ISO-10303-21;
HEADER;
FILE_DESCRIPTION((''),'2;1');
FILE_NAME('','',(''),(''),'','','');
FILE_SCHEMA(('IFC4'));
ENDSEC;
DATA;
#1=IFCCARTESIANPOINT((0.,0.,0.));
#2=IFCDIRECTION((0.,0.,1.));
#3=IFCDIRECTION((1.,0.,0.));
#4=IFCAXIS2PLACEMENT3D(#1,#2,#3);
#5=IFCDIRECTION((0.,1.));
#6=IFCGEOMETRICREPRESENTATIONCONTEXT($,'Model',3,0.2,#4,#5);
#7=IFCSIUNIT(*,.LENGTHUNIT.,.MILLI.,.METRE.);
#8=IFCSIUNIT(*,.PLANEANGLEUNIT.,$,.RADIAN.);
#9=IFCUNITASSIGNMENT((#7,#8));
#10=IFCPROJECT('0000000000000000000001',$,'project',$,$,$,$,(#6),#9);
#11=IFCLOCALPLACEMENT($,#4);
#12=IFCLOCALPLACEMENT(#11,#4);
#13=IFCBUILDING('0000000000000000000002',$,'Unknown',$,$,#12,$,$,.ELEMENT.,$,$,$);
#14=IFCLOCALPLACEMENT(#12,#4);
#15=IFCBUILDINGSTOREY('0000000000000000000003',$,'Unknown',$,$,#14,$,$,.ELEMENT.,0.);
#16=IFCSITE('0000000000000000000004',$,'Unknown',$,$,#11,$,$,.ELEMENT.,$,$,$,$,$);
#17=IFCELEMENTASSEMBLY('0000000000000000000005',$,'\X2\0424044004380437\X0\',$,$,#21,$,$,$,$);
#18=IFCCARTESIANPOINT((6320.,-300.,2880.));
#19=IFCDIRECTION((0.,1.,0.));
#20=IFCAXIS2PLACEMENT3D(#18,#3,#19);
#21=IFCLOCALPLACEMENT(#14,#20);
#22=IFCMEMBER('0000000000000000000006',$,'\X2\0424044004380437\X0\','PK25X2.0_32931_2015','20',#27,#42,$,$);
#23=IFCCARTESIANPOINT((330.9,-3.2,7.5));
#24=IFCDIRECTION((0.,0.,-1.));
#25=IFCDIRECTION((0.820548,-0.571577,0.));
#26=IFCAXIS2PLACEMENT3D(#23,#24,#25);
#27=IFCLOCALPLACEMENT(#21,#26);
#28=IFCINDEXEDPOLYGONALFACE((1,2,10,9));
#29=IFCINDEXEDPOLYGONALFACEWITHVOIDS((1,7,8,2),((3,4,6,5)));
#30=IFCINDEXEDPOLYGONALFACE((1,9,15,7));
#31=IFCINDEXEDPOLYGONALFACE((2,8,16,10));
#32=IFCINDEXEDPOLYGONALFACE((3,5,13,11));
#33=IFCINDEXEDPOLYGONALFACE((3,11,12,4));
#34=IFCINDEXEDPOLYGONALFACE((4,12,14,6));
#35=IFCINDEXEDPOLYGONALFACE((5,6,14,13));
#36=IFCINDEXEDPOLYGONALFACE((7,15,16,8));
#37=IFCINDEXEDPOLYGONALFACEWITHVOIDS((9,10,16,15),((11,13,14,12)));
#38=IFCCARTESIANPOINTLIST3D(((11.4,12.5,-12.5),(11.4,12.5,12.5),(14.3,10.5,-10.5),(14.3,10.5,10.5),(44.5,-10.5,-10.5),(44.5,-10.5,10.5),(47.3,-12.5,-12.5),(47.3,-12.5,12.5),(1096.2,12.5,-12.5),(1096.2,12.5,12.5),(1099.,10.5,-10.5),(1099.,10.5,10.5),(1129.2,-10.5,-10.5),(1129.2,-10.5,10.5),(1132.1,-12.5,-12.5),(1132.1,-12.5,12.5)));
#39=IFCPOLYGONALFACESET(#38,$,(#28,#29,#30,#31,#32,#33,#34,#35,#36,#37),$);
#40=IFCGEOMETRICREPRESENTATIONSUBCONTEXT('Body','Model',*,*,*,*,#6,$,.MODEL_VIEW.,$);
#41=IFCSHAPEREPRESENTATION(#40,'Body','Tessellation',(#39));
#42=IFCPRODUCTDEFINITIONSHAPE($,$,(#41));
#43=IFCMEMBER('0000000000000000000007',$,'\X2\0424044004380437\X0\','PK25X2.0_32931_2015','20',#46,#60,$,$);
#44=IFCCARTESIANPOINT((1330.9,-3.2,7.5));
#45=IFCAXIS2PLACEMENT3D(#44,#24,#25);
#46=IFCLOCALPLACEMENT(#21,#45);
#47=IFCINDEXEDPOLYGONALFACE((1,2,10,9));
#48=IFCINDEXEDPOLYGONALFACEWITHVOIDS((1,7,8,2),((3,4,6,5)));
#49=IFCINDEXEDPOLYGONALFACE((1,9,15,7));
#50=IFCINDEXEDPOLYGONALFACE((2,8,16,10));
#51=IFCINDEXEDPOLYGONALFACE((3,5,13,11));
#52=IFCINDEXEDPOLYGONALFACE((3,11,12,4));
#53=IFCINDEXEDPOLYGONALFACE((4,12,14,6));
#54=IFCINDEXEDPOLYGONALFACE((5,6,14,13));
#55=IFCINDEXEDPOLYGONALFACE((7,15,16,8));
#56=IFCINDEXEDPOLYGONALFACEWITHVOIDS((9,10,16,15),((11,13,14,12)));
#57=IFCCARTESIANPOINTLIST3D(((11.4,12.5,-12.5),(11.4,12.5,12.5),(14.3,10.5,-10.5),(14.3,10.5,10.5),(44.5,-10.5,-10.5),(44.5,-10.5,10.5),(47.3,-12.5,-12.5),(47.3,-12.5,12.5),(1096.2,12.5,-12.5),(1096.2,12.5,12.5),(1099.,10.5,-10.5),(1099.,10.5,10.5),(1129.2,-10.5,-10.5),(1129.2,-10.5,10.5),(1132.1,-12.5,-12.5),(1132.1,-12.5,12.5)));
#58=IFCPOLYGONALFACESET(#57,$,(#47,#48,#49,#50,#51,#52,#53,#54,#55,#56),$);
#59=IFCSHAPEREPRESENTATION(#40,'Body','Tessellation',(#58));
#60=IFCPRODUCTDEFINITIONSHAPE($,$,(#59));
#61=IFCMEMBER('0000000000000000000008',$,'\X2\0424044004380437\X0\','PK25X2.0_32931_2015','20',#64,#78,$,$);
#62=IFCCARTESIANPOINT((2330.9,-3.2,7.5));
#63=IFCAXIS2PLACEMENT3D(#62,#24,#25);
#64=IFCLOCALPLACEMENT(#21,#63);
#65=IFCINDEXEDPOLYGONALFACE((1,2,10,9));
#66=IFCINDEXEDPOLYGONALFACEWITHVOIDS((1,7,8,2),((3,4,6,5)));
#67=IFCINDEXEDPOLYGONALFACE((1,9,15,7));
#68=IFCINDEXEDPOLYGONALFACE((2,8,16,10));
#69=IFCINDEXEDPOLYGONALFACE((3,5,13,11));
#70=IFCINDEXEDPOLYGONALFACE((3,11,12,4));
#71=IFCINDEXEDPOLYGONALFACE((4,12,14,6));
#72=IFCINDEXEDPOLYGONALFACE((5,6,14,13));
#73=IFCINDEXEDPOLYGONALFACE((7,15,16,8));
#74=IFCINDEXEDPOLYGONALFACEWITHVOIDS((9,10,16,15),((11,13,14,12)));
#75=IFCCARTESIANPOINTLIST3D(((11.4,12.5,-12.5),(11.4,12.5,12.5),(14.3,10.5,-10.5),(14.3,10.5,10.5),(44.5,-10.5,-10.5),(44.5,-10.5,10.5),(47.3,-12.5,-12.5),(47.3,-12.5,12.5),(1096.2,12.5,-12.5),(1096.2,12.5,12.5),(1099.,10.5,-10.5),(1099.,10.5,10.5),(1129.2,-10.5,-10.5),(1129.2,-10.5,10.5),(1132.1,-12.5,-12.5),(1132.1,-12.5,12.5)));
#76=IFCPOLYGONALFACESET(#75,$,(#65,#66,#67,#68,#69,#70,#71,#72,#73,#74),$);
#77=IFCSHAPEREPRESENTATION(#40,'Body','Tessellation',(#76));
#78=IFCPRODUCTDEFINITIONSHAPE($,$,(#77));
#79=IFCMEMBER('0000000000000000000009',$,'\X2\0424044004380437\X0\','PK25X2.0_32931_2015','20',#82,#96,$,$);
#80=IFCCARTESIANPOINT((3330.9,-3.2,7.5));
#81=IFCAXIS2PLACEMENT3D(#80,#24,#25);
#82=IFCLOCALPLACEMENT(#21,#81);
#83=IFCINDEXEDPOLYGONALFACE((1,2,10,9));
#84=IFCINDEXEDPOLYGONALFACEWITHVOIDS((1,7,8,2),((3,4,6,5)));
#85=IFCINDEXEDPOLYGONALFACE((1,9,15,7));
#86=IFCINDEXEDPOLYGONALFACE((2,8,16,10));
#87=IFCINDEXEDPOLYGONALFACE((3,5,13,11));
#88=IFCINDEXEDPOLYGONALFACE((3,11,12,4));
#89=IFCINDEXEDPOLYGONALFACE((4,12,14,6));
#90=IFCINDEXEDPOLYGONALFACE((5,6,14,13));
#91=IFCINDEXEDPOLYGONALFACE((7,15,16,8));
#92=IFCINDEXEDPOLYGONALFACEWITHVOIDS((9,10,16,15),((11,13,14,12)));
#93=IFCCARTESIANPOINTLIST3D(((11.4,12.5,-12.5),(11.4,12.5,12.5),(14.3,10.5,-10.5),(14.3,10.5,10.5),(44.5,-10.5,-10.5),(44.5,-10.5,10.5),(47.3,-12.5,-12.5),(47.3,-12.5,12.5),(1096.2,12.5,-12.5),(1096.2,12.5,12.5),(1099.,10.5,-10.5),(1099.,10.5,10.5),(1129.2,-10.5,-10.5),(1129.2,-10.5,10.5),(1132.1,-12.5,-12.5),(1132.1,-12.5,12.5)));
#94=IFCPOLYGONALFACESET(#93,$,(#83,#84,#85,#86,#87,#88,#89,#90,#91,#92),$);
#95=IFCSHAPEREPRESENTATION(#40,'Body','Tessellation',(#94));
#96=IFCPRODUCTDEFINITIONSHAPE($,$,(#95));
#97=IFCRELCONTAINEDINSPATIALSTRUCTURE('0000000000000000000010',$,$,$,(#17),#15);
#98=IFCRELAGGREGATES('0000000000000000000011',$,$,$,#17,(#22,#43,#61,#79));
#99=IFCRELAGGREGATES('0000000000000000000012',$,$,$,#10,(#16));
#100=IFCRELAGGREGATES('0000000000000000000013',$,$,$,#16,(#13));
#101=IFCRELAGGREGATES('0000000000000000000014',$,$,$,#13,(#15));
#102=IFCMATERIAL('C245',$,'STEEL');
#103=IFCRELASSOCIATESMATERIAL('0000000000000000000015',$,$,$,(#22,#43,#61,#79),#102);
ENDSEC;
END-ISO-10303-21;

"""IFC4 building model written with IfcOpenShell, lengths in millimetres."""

from ifc_helpers import new_model, si_unit, direction, frame, origin_with_axes, place, context, subcontext, project, spatial, line, indexed_curve, outline, extrude, material, element, aggregate, save


model = new_model("IFC4")

# Units and contexts
model_context = context("Model", 3, precision=0.2, world=origin_with_axes(), true_north=direction((0.0, 1.0)))
body_context = subcontext(model_context, "Body", "Model", "MODEL_VIEW")
ifc_project = project(units=[si_unit("LENGTHUNIT", "METRE", prefix="MILLI"), si_unit("PLANEANGLEUNIT", "RADIAN")], contexts=[model_context])

# Site, building, storey
site_placement = place(None, origin_with_axes())
site = spatial("IfcSite", under=ifc_project, at=site_placement, Name="Unknown", CompositionType="ELEMENT")
building_placement = place(site_placement, origin_with_axes())
building = spatial("IfcBuilding", under=site, at=building_placement, Name="Unknown", CompositionType="ELEMENT")
storey_placement = place(building_placement, origin_with_axes())
storey = spatial("IfcBuildingStorey", under=building, at=storey_placement, Name="Unknown", CompositionType="ELEMENT", Elevation=0.0)

# Shared definitions
ifc_material_1 = material(Name="C245", Category="STEEL")

# Element assembly, members, voiding features
assembly_1_placement = place(storey_placement, frame((6320.0, -300.0, 2880.0), z_axis=(1.0, 0.0, 0.0), x_axis=(0.0, 1.0, 0.0)))
assembly_1 = element("IfcElementAssembly", 1, at=assembly_1_placement, inside=storey, Name="Фриз")
member_1_placement = place(assembly_1_placement, frame((330.9, -3.2, 7.5), z_axis=(0.0, 0.0, -1.0), x_axis=(0.820548, -0.571577, 0.0)))
member_1 = element("IfcMember", 2, at=member_1_placement, material=ifc_material_1, Name="Фриз", Description="PK25X2.0_32931_2015", ObjectType="20", context=body_context, shape_type="SolidModel", body=[
    extrude(outline(indexed_curve([(-12.5, -12.5), (12.5, -12.5), (12.5, 12.5), (-12.5, 12.5)], segments=[line(1, 2, 3, 4, 1)]), holes=[indexed_curve([(-10.5, -10.5), (-10.5, 10.5), (10.5, 10.5), (10.5, -10.5)], segments=[line(1, 2, 3, 4, 1)])]), frame((0.0, 0.0, 0.0), z_axis=(-1.0, 0.0, 0.0), x_axis=(0.0, 0.0, 1.0)), (0.0, 0.0, -1.0), 1143.5),
])
voiding_feature_1_placement = place(member_1_placement, frame((-910.3, 630.2, 7.5), z_axis=(0.0, 0.0, -1.0), x_axis=(0.820548, -0.571577, 0.0)))
element("IfcVoidingFeature", 3, at=voiding_feature_1_placement, cuts=member_1, Name="CUT_BEAM", ObjectType="(?)", PredefinedType="HOLE", context=body_context, shape_type="SolidModel", body=[
    extrude(outline(indexed_curve([(-20.0, -20.0), (20.0, -20.0), (20.0, 20.0), (-20.0, 20.0)], segments=[line(1, 2, 3, 4, 1)])), frame((0.0, 0.0, 0.0), z_axis=(-1.0, 0.0, 0.0), x_axis=(0.0, 0.0, 1.0)), (0.0, 0.0, -1.0), 2205.1),
])
voiding_feature_2_placement = place(member_1_placement, frame((244.4, 630.2, 7.5), z_axis=(0.0, 0.0, -1.0), x_axis=(0.820548, -0.571577, 0.0)))
element("IfcVoidingFeature", 4, at=voiding_feature_2_placement, cuts=member_1, Name="CUT_BEAM", ObjectType="(?)", PredefinedType="HOLE", context=body_context, shape_type="SolidModel", body=[
    extrude(outline(indexed_curve([(-20.0, -20.0), (20.0, -20.0), (20.0, 20.0), (-20.0, 20.0)], segments=[line(1, 2, 3, 4, 1)])), frame((0.0, 0.0, 0.0), z_axis=(-1.0, 0.0, 0.0), x_axis=(0.0, 0.0, 1.0)), (0.0, 0.0, -1.0), 2205.1),
])
member_2_placement = place(assembly_1_placement, frame((1330.9, -3.2, 7.5), z_axis=(0.0, 0.0, -1.0), x_axis=(0.820548, -0.571577, 0.0)))
member_2 = element("IfcMember", 5, at=member_2_placement, material=ifc_material_1, Name="Фриз", Description="PK25X2.0_32931_2015", ObjectType="20", context=body_context, shape_type="SolidModel", body=[
    extrude(outline(indexed_curve([(-12.5, -12.5), (12.5, -12.5), (12.5, 12.5), (-12.5, 12.5)], segments=[line(1, 2, 3, 4, 1)]), holes=[indexed_curve([(-10.5, -10.5), (-10.5, 10.5), (10.5, 10.5), (10.5, -10.5)], segments=[line(1, 2, 3, 4, 1)])]), frame((0.0, 0.0, 0.0), z_axis=(-1.0, 0.0, 0.0), x_axis=(0.0, 0.0, 1.0)), (0.0, 0.0, -1.0), 1143.5),
])
voiding_feature_3_placement = place(member_2_placement, frame((-910.3, 630.2, 7.5), z_axis=(0.0, 0.0, -1.0), x_axis=(0.820548, -0.571577, 0.0)))
element("IfcVoidingFeature", 6, at=voiding_feature_3_placement, cuts=member_2, Name="CUT_BEAM", ObjectType="(?)", PredefinedType="HOLE", context=body_context, shape_type="SolidModel", body=[
    extrude(outline(indexed_curve([(-20.0, -20.0), (20.0, -20.0), (20.0, 20.0), (-20.0, 20.0)], segments=[line(1, 2, 3, 4, 1)])), frame((0.0, 0.0, 0.0), z_axis=(-1.0, 0.0, 0.0), x_axis=(0.0, 0.0, 1.0)), (0.0, 0.0, -1.0), 2205.1),
])
voiding_feature_4_placement = place(member_2_placement, frame((244.4, 630.2, 7.5), z_axis=(0.0, 0.0, -1.0), x_axis=(0.820548, -0.571577, 0.0)))
element("IfcVoidingFeature", 7, at=voiding_feature_4_placement, cuts=member_2, Name="CUT_BEAM", ObjectType="(?)", PredefinedType="HOLE", context=body_context, shape_type="SolidModel", body=[
    extrude(outline(indexed_curve([(-20.0, -20.0), (20.0, -20.0), (20.0, 20.0), (-20.0, 20.0)], segments=[line(1, 2, 3, 4, 1)])), frame((0.0, 0.0, 0.0), z_axis=(-1.0, 0.0, 0.0), x_axis=(0.0, 0.0, 1.0)), (0.0, 0.0, -1.0), 2205.1),
])
member_3_placement = place(assembly_1_placement, frame((2330.9, -3.2, 7.5), z_axis=(0.0, 0.0, -1.0), x_axis=(0.820548, -0.571577, 0.0)))
member_3 = element("IfcMember", 8, at=member_3_placement, material=ifc_material_1, Name="Фриз", Description="PK25X2.0_32931_2015", ObjectType="20", context=body_context, shape_type="SolidModel", body=[
    extrude(outline(indexed_curve([(-12.5, -12.5), (12.5, -12.5), (12.5, 12.5), (-12.5, 12.5)], segments=[line(1, 2, 3, 4, 1)]), holes=[indexed_curve([(-10.5, -10.5), (-10.5, 10.5), (10.5, 10.5), (10.5, -10.5)], segments=[line(1, 2, 3, 4, 1)])]), frame((0.0, 0.0, 0.0), z_axis=(-1.0, 0.0, 0.0), x_axis=(0.0, 0.0, 1.0)), (0.0, 0.0, -1.0), 1143.5),
])
voiding_feature_5_placement = place(member_3_placement, frame((-910.3, 630.2, 7.5), z_axis=(0.0, 0.0, -1.0), x_axis=(0.820548, -0.571577, 0.0)))
element("IfcVoidingFeature", 9, at=voiding_feature_5_placement, cuts=member_3, Name="CUT_BEAM", ObjectType="(?)", PredefinedType="HOLE", context=body_context, shape_type="SolidModel", body=[
    extrude(outline(indexed_curve([(-20.0, -20.0), (20.0, -20.0), (20.0, 20.0), (-20.0, 20.0)], segments=[line(1, 2, 3, 4, 1)])), frame((0.0, 0.0, 0.0), z_axis=(-1.0, 0.0, 0.0), x_axis=(0.0, 0.0, 1.0)), (0.0, 0.0, -1.0), 2205.1),
])
voiding_feature_6_placement = place(member_3_placement, frame((244.4, 630.2, 7.5), z_axis=(0.0, 0.0, -1.0), x_axis=(0.820548, -0.571577, 0.0)))
element("IfcVoidingFeature", 10, at=voiding_feature_6_placement, cuts=member_3, Name="CUT_BEAM", ObjectType="(?)", PredefinedType="HOLE", context=body_context, shape_type="SolidModel", body=[
    extrude(outline(indexed_curve([(-20.0, -20.0), (20.0, -20.0), (20.0, 20.0), (-20.0, 20.0)], segments=[line(1, 2, 3, 4, 1)])), frame((0.0, 0.0, 0.0), z_axis=(-1.0, 0.0, 0.0), x_axis=(0.0, 0.0, 1.0)), (0.0, 0.0, -1.0), 2205.1),
])
member_4_placement = place(assembly_1_placement, frame((3330.9, -3.2, 7.5), z_axis=(0.0, 0.0, -1.0), x_axis=(0.820548, -0.571577, 0.0)))
member_4 = element("IfcMember", 11, at=member_4_placement, material=ifc_material_1, Name="Фриз", Description="PK25X2.0_32931_2015", ObjectType="20", context=body_context, shape_type="SolidModel", body=[
    extrude(outline(indexed_curve([(-12.5, -12.5), (12.5, -12.5), (12.5, 12.5), (-12.5, 12.5)], segments=[line(1, 2, 3, 4, 1)]), holes=[indexed_curve([(-10.5, -10.5), (-10.5, 10.5), (10.5, 10.5), (10.5, -10.5)], segments=[line(1, 2, 3, 4, 1)])]), frame((0.0, 0.0, 0.0), z_axis=(-1.0, 0.0, 0.0), x_axis=(0.0, 0.0, 1.0)), (0.0, 0.0, -1.0), 1143.5),
])
voiding_feature_7_placement = place(member_4_placement, frame((-910.3, 630.2, 7.5), z_axis=(0.0, 0.0, -1.0), x_axis=(0.820548, -0.571577, 0.0)))
element("IfcVoidingFeature", 12, at=voiding_feature_7_placement, cuts=member_4, Name="CUT_BEAM", ObjectType="(?)", PredefinedType="HOLE", context=body_context, shape_type="SolidModel", body=[
    extrude(outline(indexed_curve([(-20.0, -20.0), (20.0, -20.0), (20.0, 20.0), (-20.0, 20.0)], segments=[line(1, 2, 3, 4, 1)])), frame((0.0, 0.0, 0.0), z_axis=(-1.0, 0.0, 0.0), x_axis=(0.0, 0.0, 1.0)), (0.0, 0.0, -1.0), 2205.1),
])
voiding_feature_8_placement = place(member_4_placement, frame((244.4, 630.2, 7.5), z_axis=(0.0, 0.0, -1.0), x_axis=(0.820548, -0.571577, 0.0)))
element("IfcVoidingFeature", 13, at=voiding_feature_8_placement, cuts=member_4, Name="CUT_BEAM", ObjectType="(?)", PredefinedType="HOLE", context=body_context, shape_type="SolidModel", body=[
    extrude(outline(indexed_curve([(-20.0, -20.0), (20.0, -20.0), (20.0, 20.0), (-20.0, 20.0)], segments=[line(1, 2, 3, 4, 1)])), frame((0.0, 0.0, 0.0), z_axis=(-1.0, 0.0, 0.0), x_axis=(0.0, 0.0, 1.0)), (0.0, 0.0, -1.0), 2205.1),
])
aggregate(assembly_1, [member_1, member_2, member_3, member_4])

save(model, "model.ifc")
